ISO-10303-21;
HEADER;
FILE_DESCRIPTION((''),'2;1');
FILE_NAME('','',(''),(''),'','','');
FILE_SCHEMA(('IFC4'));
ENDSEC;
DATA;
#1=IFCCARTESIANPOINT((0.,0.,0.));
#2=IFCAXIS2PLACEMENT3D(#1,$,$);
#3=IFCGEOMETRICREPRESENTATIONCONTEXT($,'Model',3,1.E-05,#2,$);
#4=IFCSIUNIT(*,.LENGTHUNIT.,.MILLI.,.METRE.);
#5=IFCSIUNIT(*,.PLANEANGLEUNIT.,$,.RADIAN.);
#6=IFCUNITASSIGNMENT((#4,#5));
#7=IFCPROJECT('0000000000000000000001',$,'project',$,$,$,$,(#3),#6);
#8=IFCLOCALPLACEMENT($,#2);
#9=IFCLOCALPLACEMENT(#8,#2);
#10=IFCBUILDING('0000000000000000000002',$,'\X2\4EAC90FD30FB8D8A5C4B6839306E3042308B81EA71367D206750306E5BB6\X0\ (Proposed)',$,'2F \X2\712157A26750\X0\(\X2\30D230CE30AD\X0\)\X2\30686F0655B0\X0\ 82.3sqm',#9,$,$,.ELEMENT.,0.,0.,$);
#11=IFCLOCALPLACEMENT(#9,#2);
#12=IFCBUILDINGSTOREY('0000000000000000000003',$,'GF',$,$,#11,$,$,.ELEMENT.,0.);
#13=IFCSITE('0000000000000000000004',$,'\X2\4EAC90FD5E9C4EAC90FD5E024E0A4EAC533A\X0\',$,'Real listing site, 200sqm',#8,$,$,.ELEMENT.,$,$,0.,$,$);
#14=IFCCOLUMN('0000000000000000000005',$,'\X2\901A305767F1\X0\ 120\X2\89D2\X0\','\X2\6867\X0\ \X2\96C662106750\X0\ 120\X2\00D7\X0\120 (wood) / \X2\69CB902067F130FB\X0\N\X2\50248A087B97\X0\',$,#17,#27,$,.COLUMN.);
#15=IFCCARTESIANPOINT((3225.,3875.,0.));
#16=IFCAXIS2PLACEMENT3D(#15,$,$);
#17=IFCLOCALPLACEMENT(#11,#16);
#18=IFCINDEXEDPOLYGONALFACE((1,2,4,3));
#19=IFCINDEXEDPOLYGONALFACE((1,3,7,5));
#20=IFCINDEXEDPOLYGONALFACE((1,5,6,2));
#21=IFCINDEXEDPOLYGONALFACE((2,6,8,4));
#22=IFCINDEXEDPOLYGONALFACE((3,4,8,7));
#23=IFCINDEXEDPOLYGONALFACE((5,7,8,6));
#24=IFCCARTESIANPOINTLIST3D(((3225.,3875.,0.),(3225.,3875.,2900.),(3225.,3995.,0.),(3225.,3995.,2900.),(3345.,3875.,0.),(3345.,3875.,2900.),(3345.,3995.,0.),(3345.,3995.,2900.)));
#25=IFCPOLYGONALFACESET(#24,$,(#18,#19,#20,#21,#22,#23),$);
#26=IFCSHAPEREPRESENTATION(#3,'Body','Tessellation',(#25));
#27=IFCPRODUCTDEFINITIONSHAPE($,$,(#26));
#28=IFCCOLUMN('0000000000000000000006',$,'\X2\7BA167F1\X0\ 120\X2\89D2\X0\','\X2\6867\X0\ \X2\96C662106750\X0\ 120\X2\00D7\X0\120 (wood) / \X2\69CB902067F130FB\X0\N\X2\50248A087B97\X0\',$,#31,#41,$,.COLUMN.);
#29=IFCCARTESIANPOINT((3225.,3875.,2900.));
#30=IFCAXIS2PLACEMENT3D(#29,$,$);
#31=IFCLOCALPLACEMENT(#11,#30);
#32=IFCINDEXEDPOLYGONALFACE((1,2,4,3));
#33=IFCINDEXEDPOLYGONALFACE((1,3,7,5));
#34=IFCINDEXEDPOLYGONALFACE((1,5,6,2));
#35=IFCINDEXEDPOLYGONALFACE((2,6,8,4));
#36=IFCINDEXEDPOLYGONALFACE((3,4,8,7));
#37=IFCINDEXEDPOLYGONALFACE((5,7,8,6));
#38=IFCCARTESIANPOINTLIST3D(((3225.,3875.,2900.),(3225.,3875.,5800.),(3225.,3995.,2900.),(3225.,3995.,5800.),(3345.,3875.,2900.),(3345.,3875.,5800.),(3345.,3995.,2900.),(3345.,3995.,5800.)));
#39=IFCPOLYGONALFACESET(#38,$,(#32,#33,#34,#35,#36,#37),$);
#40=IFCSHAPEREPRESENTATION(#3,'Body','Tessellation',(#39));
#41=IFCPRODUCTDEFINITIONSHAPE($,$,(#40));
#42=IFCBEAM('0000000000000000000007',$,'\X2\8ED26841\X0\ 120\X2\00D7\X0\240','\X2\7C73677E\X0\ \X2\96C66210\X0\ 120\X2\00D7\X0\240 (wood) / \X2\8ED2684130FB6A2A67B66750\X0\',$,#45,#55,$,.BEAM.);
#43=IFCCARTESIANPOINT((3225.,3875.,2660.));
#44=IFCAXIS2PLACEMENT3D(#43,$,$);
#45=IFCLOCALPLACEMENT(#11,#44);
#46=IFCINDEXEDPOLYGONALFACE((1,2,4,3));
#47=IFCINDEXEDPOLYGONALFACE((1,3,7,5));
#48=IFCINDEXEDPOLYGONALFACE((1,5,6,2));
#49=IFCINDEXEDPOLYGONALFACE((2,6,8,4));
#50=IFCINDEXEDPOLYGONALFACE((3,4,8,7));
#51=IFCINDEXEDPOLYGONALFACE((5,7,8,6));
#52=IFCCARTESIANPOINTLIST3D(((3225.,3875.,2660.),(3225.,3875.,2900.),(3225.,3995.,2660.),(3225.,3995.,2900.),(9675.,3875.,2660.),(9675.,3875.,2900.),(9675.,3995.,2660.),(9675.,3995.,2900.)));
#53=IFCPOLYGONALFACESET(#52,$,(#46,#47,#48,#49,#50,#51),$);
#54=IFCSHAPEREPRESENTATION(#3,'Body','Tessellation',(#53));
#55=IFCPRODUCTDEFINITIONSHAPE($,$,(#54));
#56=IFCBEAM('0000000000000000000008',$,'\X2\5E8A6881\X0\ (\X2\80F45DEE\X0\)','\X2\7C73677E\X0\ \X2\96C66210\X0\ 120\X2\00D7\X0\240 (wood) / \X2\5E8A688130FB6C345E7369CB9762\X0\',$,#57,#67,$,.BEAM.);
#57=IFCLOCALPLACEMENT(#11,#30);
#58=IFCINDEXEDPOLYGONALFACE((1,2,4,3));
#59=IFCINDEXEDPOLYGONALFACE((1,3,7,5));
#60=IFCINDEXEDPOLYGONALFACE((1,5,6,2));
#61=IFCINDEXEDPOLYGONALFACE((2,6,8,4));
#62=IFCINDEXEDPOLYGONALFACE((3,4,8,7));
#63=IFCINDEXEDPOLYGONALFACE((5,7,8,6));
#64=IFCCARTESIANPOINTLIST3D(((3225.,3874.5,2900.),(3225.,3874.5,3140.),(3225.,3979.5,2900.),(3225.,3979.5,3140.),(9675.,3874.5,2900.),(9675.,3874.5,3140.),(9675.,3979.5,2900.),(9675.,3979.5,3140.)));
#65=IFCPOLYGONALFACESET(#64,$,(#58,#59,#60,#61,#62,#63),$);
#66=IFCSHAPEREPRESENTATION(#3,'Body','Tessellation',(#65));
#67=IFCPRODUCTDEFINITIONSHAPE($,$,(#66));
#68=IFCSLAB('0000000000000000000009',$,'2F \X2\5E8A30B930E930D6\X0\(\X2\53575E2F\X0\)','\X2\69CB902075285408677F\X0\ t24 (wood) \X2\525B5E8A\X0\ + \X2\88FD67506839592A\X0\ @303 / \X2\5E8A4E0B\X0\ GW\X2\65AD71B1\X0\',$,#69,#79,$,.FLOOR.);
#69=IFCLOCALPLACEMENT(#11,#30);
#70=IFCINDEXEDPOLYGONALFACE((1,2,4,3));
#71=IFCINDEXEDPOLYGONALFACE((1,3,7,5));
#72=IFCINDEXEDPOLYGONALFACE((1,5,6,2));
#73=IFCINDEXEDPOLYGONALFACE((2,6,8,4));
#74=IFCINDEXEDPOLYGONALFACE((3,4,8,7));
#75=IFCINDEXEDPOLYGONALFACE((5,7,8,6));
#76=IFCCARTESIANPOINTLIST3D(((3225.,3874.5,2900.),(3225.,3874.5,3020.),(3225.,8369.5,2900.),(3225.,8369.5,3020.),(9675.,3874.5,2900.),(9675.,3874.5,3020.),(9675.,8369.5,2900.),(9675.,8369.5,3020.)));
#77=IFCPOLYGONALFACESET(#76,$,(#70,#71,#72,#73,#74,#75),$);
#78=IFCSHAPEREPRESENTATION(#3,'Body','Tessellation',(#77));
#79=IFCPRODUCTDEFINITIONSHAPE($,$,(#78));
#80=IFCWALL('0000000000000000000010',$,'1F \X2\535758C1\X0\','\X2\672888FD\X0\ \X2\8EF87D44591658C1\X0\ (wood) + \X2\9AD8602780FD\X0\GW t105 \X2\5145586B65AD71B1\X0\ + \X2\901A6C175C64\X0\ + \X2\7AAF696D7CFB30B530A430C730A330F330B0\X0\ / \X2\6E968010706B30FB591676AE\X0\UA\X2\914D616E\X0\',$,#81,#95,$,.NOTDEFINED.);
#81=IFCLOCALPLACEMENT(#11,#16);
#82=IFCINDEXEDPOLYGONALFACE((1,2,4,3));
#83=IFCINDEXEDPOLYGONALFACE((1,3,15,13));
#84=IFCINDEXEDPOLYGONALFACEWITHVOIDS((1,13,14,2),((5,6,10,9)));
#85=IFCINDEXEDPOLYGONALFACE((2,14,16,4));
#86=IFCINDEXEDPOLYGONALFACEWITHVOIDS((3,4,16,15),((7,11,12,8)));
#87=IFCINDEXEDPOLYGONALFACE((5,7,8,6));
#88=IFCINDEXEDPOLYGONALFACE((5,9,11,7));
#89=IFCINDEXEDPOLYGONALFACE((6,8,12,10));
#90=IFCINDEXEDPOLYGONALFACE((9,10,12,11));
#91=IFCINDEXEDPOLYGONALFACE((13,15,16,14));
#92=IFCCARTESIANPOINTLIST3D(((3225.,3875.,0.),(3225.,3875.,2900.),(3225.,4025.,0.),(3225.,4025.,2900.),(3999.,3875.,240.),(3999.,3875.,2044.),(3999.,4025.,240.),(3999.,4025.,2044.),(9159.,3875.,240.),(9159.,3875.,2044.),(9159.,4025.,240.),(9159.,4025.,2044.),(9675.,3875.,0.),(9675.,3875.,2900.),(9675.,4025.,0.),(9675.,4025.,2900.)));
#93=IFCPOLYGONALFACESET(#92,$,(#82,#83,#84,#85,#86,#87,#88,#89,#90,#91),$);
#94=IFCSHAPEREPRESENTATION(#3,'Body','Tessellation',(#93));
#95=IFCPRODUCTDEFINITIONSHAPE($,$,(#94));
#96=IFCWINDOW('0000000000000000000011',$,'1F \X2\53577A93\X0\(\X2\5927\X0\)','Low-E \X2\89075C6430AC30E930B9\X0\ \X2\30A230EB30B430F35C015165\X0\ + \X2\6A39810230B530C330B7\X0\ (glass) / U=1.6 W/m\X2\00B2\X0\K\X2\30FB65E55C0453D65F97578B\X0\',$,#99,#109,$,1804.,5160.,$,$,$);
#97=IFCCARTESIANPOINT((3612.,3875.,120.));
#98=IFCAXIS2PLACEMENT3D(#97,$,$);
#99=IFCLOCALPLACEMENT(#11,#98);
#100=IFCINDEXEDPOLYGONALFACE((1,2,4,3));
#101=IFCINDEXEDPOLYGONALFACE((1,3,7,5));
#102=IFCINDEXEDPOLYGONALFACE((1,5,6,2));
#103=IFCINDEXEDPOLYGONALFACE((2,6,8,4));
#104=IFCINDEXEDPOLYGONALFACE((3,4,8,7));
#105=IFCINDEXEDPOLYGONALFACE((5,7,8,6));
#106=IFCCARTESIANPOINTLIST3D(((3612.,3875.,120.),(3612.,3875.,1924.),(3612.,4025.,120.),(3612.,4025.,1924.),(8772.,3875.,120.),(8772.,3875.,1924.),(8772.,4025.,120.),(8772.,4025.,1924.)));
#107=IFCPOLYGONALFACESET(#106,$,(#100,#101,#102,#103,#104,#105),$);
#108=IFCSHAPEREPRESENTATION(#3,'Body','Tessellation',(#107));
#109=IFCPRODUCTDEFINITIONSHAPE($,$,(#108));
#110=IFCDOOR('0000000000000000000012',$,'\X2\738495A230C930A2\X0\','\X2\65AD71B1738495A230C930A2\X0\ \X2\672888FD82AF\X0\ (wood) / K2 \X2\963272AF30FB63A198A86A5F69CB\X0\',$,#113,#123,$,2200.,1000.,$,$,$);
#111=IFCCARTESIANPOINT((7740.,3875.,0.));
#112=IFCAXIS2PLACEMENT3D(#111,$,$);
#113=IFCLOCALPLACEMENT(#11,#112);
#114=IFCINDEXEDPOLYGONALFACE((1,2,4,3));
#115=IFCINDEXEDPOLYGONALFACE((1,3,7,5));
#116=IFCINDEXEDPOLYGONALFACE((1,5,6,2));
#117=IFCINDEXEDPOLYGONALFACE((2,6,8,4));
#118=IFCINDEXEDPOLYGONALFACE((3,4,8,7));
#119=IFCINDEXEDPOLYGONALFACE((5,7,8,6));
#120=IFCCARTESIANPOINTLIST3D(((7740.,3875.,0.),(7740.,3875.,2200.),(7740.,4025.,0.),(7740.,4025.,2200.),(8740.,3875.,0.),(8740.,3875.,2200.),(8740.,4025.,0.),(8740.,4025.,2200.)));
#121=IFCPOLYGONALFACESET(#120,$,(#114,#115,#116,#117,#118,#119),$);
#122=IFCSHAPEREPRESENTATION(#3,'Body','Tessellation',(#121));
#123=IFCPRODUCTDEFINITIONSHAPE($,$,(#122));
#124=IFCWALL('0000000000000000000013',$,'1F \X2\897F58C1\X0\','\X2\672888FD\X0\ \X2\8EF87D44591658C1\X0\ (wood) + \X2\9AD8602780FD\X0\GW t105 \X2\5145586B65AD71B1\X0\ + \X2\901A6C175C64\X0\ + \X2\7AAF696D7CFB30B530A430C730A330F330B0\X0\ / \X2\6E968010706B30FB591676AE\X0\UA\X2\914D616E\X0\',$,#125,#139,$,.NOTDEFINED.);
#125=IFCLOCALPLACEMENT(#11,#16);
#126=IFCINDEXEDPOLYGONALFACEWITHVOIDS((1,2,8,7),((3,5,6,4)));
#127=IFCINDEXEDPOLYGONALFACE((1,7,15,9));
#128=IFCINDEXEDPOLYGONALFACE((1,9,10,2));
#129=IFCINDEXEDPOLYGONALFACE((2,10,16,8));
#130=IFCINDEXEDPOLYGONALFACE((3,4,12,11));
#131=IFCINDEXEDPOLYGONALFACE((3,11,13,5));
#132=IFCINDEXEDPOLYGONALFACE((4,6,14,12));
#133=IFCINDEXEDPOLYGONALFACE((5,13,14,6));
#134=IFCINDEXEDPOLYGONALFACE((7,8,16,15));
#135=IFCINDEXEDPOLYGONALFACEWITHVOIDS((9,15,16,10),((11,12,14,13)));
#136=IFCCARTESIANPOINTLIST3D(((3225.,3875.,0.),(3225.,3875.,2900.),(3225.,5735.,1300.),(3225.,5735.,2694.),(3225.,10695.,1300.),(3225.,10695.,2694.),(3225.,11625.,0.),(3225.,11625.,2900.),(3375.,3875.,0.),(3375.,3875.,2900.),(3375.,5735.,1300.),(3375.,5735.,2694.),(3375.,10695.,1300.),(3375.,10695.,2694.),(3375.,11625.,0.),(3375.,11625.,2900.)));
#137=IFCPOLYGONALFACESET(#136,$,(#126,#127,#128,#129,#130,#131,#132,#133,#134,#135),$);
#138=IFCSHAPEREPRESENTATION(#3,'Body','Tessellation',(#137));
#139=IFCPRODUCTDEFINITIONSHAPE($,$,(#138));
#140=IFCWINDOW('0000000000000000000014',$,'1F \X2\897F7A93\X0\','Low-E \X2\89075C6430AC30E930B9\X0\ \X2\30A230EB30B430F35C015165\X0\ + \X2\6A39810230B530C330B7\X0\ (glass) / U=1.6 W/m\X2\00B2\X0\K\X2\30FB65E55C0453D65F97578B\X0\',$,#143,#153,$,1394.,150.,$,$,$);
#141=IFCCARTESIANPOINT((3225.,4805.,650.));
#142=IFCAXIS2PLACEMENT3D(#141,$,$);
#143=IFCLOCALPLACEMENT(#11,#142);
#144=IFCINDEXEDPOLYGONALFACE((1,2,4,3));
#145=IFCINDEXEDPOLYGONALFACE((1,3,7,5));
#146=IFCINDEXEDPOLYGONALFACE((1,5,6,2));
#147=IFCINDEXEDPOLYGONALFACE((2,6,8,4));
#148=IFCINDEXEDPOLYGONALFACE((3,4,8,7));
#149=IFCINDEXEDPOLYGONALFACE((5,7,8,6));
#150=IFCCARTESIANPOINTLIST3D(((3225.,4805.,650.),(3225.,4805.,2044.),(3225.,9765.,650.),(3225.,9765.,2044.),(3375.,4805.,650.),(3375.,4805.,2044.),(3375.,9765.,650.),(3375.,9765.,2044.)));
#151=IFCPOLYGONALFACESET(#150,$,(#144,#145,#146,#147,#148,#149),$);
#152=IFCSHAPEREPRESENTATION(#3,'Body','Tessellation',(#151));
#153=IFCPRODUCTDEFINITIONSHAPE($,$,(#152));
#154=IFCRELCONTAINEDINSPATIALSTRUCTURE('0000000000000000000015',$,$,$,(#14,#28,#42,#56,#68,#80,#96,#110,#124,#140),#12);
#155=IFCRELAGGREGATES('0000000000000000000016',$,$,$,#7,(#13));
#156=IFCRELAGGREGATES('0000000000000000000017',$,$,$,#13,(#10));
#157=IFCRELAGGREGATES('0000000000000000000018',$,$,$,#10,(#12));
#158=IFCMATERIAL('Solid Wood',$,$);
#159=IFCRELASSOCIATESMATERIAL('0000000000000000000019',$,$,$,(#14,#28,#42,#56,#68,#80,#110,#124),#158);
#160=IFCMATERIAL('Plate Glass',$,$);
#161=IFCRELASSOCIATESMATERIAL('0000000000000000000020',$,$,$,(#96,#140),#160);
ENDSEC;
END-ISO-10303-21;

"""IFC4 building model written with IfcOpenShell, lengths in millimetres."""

from ifc_helpers import new_model, si_unit, frame, frame_2d, origin, place, context, project, spatial, rectangle, extrude, material, element, fill, save


model = new_model("IFC4")

# Units and contexts
model_context = context("Model", 3, precision=1e-05, world=origin())
ifc_project = project(units=[si_unit("LENGTHUNIT", "METRE", prefix="MILLI"), si_unit("PLANEANGLEUNIT", "RADIAN")], contexts=[model_context])

# Site, building, storey
site_placement = place(None, origin())
site = spatial("IfcSite", under=ifc_project, at=site_placement, Name="京都府京都市上京区", ObjectType="Real listing site, 200sqm", CompositionType="ELEMENT", RefElevation=0.0)
building_placement = place(site_placement, origin())
building = spatial("IfcBuilding", under=site, at=building_placement, Name="京都・越屋根のある自然素材の家 (Proposed)", ObjectType="2F 無垢材(ヒノキ)と漆喰 82.3sqm", CompositionType="ELEMENT", ElevationOfRefHeight=0.0, ElevationOfTerrain=0.0)
storey_placement = place(building_placement, origin())
storey = spatial("IfcBuildingStorey", under=building, at=storey_placement, Name="GF", CompositionType="ELEMENT", Elevation=0.0)

# Columns
ifc_material_1 = material(Name="Solid Wood")
column_1_placement = place(storey_placement, frame((3225.0, 3875.0, 0.0)))
element("IfcColumn", 1, at=column_1_placement, inside=storey, material=ifc_material_1, Name="通し柱 120角", Description="桧 集成材 120×120 (wood) / 構造柱・N値計算", PredefinedType="COLUMN", context=model_context, shape_type="SweptSolid", body=[
    extrude(rectangle(XDim=120.0, YDim=120.0, at=frame_2d((60.0, 60.0))), frame((3225.0, 3875.0, 0.0)), (0.0, 0.0, 1.0), 2900.0),
])
column_2_placement = place(storey_placement, frame((3225.0, 3875.0, 2900.0)))
element("IfcColumn", 2, at=column_2_placement, inside=storey, material=ifc_material_1, Name="管柱 120角", Description="桧 集成材 120×120 (wood) / 構造柱・N値計算", PredefinedType="COLUMN", context=model_context, shape_type="SweptSolid", body=[
    extrude(rectangle(XDim=120.0, YDim=120.0, at=frame_2d((60.0, 60.0))), frame((3225.0, 3875.0, 2900.0)), (0.0, 0.0, 1.0), 2900.0),
])

# Beams
beam_1_placement = place(storey_placement, frame((3225.0, 3875.0, 2660.0)))
element("IfcBeam", 3, at=beam_1_placement, inside=storey, material=ifc_material_1, Name="軒桁 120×240", Description="米松 集成 120×240 (wood) / 軒桁・横架材", PredefinedType="BEAM", context=model_context, shape_type="SweptSolid", body=[
    extrude(rectangle(XDim=6450.0, YDim=120.0, at=frame_2d((3225.0, 60.0))), frame((3225.0, 3875.0, 2660.0)), (0.0, 0.0, 1.0), 240.0),
])
beam_2_placement = place(storey_placement, frame((3225.0, 3875.0, 2900.0)))
element("IfcBeam", 4, at=beam_2_placement, inside=storey, material=ifc_material_1, Name="床梁 (胴差)", Description="米松 集成 120×240 (wood) / 床梁・水平構面", PredefinedType="BEAM", context=model_context, shape_type="SweptSolid", body=[
    extrude(rectangle(XDim=6450.0, YDim=105.0, at=frame_2d((3225.0, 52.0))), frame((3225.0, 3875.0, 2900.0)), (0.0, 0.0, 1.0), 240.0),
])

# Slab
slab_1_placement = place(storey_placement, frame((3225.0, 3875.0, 2900.0)))
element("IfcSlab", 5, at=slab_1_placement, inside=storey, material=ifc_material_1, Name="2F 床スラブ(南帯)", Description="構造用合板 t24 (wood) 剛床 + 製材根太 @303 / 床下 GW断熱", PredefinedType="FLOOR", context=model_context, shape_type="SweptSolid", body=[
    extrude(rectangle(XDim=6450.0, YDim=4495.0, at=frame_2d((3225.0, 2247.0))), frame((3225.0, 3875.0, 2900.0)), (0.0, 0.0, 1.0), 120.0),
])

# Wall, openings, window, door
wall_1_placement = place(storey_placement, frame((3225.0, 3875.0, 0.0)))
wall_1 = element("IfcWall", 6, at=wall_1_placement, inside=storey, material=ifc_material_1, Name="1F 南壁", Description="木製 軸組外壁 (wood) + 高性能GW t105 充填断熱 + 通気層 + 窯業系サイディング / 準耐火・外皮UA配慮", PredefinedType="NOTDEFINED", context=model_context, shape_type="SweptSolid", body=[
    extrude(rectangle(XDim=6450.0, YDim=150.0, at=frame_2d((3225.0, 75.0))), frame((3225.0, 3875.0, 0.0)), (0.0, 0.0, 1.0), 2900.0),
])
opening_1_placement = place(storey_placement, frame((3612.0, 3875.0, 120.0)))
opening_1 = element("IfcOpeningElement", 7, at=opening_1_placement, cuts=wall_1, PredefinedType="NOTDEFINED", context=model_context, shape_type="SweptSolid", body=[
    extrude(rectangle(XDim=5160.0, YDim=150.0, at=frame_2d((2580.0, 75.0))), frame((3612.0, 3875.0, 120.0)), (0.0, 0.0, 1.0), 1804.0),
])
opening_2_placement = place(storey_placement, frame((7740.0, 3875.0, 0.0)))
opening_2 = element("IfcOpeningElement", 8, at=opening_2_placement, cuts=wall_1, PredefinedType="NOTDEFINED", context=model_context, shape_type="SweptSolid", body=[
    extrude(rectangle(XDim=1000.0, YDim=150.0, at=frame_2d((500.0, 75.0))), frame((7740.0, 3875.0, 0.0)), (0.0, 0.0, 1.0), 2200.0),
])
ifc_material_2 = material(Name="Plate Glass")
window_1_placement = place(storey_placement, frame((3612.0, 3875.0, 120.0)))
window_1 = element("IfcWindow", 9, at=window_1_placement, inside=storey, material=ifc_material_2, Name="1F 南窓(大)", Description="Low-E 複層ガラス アルゴン封入 + 樹脂サッシ (glass) / U=1.6 W/m²K・日射取得型", OverallHeight=1804.0, OverallWidth=5160.0, context=model_context, shape_type="SweptSolid", body=[
    extrude(rectangle(XDim=5160.0, YDim=150.0, at=frame_2d((2580.0, 75.0))), frame((3612.0, 3875.0, 120.0)), (0.0, 0.0, 1.0), 1804.0),
])
fill(opening_1, window_1)
door_placement = place(storey_placement, frame((7740.0, 3875.0, 0.0)))
door = element("IfcDoor", 10, at=door_placement, inside=storey, material=ifc_material_1, Name="玄関ドア", Description="断熱玄関ドア 木製芯 (wood) / K2 防犯・採風機構", OverallHeight=2200.0, OverallWidth=1000.0, context=model_context, shape_type="SweptSolid", body=[
    extrude(rectangle(XDim=1000.0, YDim=150.0, at=frame_2d((500.0, 75.0))), frame((7740.0, 3875.0, 0.0)), (0.0, 0.0, 1.0), 2200.0),
])
fill(opening_2, door)

# Wall, opening, window
wall_2_placement = place(storey_placement, frame((3225.0, 3875.0, 0.0)))
wall_2 = element("IfcWall", 11, at=wall_2_placement, inside=storey, material=ifc_material_1, Name="1F 西壁", Description="木製 軸組外壁 (wood) + 高性能GW t105 充填断熱 + 通気層 + 窯業系サイディング / 準耐火・外皮UA配慮", PredefinedType="NOTDEFINED", context=model_context, shape_type="SweptSolid", body=[
    extrude(rectangle(XDim=150.0, YDim=7750.0, at=frame_2d((75.0, 3875.0))), frame((3225.0, 3875.0, 0.0)), (0.0, 0.0, 1.0), 2900.0),
])
opening_3_placement = place(storey_placement, frame((3225.0, 4805.0, 650.0)))
opening_3 = element("IfcOpeningElement", 12, at=opening_3_placement, cuts=wall_2, PredefinedType="NOTDEFINED", context=model_context, shape_type="SweptSolid", body=[
    extrude(rectangle(XDim=150.0, YDim=4960.0, at=frame_2d((75.0, 2480.0))), frame((3225.0, 4805.0, 650.0)), (0.0, 0.0, 1.0), 1394.0),
])
window_2_placement = place(storey_placement, frame((3225.0, 4805.0, 650.0)))
window_2 = element("IfcWindow", 13, at=window_2_placement, inside=storey, material=ifc_material_2, Name="1F 西窓", Description="Low-E 複層ガラス アルゴン封入 + 樹脂サッシ (glass) / U=1.6 W/m²K・日射取得型", OverallHeight=1394.0, OverallWidth=150.0, context=model_context, shape_type="SweptSolid", body=[
    extrude(rectangle(XDim=150.0, YDim=4960.0, at=frame_2d((75.0, 2480.0))), frame((3225.0, 4805.0, 650.0)), (0.0, 0.0, 1.0), 1394.0),
])
fill(opening_3, window_2)

save(model, "model.ifc")
